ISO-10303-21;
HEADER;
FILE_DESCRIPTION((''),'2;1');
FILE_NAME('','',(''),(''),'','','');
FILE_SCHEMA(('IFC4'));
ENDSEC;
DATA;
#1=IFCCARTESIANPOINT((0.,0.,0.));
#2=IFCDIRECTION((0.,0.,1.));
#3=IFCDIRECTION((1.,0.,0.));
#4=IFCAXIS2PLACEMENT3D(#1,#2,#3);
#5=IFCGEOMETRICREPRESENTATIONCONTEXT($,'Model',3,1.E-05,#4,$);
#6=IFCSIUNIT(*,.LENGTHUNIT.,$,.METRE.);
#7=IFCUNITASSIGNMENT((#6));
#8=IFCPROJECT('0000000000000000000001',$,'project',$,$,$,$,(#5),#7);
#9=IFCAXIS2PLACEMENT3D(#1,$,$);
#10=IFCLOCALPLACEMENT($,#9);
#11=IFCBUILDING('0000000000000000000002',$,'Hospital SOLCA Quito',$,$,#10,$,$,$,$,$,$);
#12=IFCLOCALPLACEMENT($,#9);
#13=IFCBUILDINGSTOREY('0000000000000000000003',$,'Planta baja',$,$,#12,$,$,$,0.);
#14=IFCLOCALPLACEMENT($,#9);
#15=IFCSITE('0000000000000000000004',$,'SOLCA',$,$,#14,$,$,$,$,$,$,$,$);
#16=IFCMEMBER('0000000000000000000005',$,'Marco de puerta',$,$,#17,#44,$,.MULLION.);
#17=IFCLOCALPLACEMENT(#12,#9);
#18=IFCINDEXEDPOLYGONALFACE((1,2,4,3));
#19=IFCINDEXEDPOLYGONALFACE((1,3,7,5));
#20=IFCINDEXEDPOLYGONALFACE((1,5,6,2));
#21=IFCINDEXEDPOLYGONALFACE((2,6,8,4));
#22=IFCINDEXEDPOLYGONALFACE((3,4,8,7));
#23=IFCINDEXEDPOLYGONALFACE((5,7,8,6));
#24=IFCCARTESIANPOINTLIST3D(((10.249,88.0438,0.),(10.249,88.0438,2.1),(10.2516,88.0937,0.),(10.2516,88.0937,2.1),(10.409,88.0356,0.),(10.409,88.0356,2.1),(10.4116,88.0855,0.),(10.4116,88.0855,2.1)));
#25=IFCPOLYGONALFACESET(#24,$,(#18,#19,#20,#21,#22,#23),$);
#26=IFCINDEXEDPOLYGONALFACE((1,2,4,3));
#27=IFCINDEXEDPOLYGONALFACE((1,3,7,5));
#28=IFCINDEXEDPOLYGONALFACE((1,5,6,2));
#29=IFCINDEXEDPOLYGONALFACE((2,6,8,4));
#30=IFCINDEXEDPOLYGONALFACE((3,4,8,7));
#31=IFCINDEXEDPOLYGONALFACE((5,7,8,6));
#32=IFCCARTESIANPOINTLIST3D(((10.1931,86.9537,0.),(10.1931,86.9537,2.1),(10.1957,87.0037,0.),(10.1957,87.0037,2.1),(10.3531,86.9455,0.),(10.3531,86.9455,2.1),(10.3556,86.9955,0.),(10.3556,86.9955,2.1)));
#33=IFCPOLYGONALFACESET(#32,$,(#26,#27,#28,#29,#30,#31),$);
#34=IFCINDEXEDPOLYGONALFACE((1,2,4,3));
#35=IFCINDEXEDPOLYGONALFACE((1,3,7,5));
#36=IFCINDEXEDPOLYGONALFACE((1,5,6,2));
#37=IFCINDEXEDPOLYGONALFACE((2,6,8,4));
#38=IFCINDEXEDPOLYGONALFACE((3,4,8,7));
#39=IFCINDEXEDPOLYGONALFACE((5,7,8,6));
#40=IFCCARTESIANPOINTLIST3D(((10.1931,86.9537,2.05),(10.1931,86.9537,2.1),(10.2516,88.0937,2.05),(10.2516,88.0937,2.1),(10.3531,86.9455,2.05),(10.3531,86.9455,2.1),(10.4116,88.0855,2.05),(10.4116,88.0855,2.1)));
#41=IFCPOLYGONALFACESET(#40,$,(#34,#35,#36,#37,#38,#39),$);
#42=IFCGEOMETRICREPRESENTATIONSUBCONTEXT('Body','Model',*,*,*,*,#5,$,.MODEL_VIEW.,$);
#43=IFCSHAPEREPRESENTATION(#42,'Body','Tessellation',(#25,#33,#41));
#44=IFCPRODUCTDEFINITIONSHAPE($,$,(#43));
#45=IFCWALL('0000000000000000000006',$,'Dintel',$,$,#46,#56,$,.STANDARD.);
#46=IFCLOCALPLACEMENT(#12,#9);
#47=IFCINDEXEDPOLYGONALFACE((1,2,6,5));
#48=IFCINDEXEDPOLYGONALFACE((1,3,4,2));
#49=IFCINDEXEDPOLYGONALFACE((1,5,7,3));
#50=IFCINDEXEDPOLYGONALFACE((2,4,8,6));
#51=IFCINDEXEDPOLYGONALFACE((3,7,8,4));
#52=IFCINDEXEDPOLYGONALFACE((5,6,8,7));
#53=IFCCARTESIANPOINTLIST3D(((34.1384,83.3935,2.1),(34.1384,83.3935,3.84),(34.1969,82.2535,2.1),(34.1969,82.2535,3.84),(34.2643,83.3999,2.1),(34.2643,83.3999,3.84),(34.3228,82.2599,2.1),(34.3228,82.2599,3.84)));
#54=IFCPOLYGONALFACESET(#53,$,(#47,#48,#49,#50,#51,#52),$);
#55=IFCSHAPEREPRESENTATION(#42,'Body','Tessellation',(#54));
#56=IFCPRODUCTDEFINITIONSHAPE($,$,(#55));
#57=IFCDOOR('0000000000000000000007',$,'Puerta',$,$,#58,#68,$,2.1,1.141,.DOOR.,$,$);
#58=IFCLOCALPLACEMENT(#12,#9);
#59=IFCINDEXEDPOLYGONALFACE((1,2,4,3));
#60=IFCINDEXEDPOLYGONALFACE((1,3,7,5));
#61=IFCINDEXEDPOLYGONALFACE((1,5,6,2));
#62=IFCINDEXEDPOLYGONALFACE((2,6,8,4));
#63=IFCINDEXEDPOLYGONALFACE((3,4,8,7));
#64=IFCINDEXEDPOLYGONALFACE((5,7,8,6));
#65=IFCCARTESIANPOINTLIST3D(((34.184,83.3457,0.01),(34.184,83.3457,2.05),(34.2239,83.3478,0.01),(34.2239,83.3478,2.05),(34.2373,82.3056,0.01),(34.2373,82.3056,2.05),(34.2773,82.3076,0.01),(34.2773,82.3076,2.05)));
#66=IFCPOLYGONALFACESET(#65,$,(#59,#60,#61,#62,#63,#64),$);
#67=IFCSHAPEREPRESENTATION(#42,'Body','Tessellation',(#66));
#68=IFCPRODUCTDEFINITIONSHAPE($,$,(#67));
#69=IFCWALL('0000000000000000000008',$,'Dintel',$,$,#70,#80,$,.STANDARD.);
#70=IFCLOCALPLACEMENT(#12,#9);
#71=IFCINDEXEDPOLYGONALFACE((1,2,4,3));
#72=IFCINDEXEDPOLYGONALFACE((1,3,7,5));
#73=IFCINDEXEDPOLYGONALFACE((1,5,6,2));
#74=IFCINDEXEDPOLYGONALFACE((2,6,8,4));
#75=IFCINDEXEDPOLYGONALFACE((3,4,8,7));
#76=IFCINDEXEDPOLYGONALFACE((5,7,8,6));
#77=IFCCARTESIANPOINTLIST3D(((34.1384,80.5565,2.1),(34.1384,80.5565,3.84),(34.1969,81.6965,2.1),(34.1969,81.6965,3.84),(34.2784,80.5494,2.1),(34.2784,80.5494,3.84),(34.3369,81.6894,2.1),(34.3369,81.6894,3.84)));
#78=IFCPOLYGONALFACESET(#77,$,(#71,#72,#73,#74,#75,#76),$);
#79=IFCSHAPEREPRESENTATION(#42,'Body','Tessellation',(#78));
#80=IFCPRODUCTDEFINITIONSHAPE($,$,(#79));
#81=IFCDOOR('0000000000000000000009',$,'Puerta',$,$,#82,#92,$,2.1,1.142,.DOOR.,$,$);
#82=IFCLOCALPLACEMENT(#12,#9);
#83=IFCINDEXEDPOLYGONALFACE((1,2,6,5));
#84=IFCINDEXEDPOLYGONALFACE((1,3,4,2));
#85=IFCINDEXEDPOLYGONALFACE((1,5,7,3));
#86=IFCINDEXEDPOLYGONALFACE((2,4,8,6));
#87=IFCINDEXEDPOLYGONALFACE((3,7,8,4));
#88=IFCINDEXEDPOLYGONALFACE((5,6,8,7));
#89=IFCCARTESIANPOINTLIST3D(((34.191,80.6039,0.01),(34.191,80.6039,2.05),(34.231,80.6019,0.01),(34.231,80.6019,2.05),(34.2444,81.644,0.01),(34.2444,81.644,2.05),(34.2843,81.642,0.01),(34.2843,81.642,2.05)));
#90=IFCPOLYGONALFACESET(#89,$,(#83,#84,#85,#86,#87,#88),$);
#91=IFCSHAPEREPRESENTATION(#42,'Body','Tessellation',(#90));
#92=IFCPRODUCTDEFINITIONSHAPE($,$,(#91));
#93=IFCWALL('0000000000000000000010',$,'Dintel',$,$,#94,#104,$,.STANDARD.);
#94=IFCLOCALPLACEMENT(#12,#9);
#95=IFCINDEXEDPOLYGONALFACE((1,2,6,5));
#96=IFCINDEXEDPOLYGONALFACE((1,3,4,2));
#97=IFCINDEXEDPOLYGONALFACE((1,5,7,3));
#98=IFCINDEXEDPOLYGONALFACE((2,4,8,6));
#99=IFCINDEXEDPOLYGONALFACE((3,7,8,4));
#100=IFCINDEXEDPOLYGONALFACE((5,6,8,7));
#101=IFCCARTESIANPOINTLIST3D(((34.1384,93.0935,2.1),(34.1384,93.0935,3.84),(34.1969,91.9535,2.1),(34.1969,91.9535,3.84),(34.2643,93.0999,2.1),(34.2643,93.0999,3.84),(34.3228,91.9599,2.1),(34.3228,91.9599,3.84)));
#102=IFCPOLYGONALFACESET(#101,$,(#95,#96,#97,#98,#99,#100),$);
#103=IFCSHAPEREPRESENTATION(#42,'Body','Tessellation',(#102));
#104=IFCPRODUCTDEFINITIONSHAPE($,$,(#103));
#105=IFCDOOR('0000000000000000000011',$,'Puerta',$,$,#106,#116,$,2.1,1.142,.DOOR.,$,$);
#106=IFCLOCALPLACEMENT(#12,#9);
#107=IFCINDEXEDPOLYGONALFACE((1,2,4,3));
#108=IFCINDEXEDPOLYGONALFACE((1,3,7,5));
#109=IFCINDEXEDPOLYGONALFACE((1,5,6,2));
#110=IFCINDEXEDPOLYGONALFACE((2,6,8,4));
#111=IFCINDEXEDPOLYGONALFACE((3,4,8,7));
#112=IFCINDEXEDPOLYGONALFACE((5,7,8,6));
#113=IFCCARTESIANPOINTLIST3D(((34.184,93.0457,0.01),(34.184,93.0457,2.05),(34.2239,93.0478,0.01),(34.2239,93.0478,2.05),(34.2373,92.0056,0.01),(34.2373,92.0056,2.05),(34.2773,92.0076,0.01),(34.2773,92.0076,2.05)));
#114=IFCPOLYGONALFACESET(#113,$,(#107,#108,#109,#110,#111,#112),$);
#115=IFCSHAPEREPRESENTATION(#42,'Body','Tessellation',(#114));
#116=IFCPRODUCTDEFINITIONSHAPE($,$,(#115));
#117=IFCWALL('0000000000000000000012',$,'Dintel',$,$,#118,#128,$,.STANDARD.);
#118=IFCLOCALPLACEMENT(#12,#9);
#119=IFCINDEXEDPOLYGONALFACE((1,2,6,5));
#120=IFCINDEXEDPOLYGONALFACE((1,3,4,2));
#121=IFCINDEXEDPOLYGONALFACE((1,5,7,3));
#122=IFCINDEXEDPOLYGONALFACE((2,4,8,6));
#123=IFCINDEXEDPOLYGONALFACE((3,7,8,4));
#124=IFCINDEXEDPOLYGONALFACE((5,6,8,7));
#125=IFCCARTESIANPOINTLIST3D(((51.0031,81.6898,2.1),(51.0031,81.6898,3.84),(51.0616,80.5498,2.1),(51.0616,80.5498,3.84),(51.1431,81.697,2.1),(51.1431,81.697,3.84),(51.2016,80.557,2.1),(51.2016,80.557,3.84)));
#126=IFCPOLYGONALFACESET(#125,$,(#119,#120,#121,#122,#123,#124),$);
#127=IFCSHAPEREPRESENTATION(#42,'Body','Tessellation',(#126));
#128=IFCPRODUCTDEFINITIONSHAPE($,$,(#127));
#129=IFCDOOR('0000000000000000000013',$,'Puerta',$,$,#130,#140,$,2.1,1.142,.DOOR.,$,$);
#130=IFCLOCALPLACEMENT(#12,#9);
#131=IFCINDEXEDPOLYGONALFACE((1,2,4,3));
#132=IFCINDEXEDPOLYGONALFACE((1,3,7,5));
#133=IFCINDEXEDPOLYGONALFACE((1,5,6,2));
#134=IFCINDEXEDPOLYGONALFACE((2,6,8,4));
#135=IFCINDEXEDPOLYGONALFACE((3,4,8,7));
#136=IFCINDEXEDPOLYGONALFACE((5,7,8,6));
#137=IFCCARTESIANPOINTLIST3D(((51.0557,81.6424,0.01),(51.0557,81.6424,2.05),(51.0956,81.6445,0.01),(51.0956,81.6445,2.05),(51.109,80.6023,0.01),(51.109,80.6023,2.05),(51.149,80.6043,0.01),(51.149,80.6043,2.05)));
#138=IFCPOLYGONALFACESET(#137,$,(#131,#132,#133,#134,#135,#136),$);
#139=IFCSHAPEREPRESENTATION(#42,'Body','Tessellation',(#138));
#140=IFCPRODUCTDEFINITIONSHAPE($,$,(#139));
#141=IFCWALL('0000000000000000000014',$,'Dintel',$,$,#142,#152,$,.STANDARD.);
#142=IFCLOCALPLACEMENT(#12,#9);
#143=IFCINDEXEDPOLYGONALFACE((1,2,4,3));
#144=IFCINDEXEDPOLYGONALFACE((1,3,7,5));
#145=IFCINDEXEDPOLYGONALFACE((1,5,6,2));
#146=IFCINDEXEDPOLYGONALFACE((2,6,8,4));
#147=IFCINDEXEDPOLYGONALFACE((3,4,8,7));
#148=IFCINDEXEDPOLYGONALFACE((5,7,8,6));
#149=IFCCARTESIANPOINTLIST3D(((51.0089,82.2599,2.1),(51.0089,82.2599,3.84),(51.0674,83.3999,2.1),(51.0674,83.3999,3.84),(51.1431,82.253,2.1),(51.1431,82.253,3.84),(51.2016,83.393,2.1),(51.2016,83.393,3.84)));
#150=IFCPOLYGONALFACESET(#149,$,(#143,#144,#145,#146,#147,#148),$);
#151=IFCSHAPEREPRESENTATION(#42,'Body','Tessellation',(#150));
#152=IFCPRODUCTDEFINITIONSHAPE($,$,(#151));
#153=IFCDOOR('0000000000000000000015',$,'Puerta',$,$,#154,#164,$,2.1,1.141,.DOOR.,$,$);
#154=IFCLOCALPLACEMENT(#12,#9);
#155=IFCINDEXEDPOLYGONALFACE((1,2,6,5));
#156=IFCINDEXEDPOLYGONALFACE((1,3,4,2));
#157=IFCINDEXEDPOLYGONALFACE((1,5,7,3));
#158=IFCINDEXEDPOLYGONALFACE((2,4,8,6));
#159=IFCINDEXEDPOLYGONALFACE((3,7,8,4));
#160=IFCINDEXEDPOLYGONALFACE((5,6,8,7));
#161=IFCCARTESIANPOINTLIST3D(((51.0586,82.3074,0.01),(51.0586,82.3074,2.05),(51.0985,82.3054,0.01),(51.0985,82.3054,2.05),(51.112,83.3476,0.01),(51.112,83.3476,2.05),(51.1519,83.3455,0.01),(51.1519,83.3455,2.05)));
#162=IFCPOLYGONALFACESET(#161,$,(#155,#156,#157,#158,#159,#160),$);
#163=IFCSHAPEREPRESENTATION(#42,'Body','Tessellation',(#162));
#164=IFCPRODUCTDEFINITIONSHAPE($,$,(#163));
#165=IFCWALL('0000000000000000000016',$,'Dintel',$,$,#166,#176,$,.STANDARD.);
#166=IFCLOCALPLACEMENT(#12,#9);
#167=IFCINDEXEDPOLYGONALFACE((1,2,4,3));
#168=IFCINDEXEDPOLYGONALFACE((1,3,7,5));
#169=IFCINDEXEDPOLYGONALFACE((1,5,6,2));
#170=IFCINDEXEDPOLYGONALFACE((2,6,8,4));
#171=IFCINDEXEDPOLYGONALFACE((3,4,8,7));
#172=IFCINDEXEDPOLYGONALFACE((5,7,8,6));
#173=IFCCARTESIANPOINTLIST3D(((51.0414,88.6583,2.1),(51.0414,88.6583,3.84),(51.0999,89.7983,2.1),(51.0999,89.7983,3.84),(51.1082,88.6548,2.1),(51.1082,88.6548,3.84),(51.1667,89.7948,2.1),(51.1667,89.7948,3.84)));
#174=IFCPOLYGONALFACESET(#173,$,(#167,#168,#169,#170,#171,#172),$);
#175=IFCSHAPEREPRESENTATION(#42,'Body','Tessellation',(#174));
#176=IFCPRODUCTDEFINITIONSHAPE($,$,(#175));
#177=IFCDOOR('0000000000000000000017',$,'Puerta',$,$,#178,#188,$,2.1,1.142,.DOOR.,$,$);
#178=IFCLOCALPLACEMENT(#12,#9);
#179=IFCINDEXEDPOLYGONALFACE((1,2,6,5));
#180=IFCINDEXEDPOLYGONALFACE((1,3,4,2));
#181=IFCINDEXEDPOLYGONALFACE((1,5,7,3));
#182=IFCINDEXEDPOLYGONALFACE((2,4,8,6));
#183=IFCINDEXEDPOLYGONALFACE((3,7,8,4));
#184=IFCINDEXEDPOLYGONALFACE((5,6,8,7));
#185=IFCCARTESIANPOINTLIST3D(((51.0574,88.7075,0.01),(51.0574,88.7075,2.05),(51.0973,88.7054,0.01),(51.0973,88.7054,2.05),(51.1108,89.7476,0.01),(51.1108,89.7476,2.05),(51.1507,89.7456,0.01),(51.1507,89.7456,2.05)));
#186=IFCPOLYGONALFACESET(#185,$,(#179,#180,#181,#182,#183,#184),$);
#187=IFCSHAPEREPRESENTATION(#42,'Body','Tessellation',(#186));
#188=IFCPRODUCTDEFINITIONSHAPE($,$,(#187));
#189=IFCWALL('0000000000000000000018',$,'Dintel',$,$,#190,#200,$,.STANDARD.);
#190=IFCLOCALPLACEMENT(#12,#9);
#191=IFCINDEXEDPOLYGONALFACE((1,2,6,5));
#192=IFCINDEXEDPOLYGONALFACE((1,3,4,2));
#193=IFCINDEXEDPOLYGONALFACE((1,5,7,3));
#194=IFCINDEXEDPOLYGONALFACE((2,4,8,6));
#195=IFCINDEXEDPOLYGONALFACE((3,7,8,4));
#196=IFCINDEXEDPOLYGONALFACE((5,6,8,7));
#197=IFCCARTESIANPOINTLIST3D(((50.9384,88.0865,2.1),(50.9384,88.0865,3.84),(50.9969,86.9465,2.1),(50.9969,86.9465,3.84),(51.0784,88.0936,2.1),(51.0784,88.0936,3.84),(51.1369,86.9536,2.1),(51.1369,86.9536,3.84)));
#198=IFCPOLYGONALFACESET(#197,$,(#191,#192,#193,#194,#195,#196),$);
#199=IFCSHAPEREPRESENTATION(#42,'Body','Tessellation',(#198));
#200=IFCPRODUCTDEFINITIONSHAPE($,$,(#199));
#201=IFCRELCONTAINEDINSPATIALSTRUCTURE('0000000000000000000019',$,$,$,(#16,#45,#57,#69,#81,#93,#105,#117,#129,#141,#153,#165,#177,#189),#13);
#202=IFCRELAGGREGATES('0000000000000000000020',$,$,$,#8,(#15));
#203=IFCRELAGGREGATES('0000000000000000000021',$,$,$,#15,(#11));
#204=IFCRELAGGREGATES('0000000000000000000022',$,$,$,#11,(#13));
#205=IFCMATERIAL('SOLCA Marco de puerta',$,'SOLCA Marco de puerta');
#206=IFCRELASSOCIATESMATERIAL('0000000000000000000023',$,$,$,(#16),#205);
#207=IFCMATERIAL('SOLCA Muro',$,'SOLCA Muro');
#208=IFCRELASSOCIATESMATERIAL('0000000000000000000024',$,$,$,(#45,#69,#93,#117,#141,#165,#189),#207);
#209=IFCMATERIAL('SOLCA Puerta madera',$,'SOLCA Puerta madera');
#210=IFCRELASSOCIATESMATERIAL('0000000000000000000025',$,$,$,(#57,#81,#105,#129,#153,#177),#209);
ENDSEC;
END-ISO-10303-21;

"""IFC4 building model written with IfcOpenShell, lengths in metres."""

from ifc_helpers import new_model, si_unit, frame, origin, origin_with_axes, place, context, subcontext, project, spatial, polyline, outline, extrude, material, element, save


model = new_model("IFC4")

# Units and contexts
model_context = context("Model", 3, precision=1e-05, world=origin_with_axes())
body_context = subcontext(model_context, "Body", "Model", "MODEL_VIEW")
ifc_project = project(units=[si_unit("LENGTHUNIT", "METRE")], contexts=[model_context])

# Site, building, storey
site_placement = place(None, origin())
site = spatial("IfcSite", under=ifc_project, at=site_placement, Name="SOLCA")
building_placement = place(None, origin())
building = spatial("IfcBuilding", under=site, at=building_placement, Name="Hospital SOLCA Quito")
storey_placement = place(None, origin())
storey = spatial("IfcBuildingStorey", under=building, at=storey_placement, Name="Planta baja", Elevation=0.0)

# Member
ifc_material_1 = material(Name="SOLCA Marco de puerta", Category="SOLCA Marco de puerta")
member_1_placement = place(storey_placement, origin_with_axes())
element("IfcMember", 1, at=member_1_placement, inside=storey, material=ifc_material_1, Name="Marco de puerta", PredefinedType="MULLION", context=body_context, shape_type="SweptSolid", body=[
    extrude(outline(polyline([(10.2516, 88.0937), (10.249, 88.0438), (10.409, 88.0356), (10.4116, 88.0855), (10.2516, 88.0937)])), origin_with_axes(), (0.0, 0.0, 1.0), 2.1),
    extrude(outline(polyline([(10.1957, 87.0037), (10.1931, 86.9537), (10.3531, 86.9455), (10.3556, 86.9955), (10.1957, 87.0037)])), origin_with_axes(), (0.0, 0.0, 1.0), 2.1),
    extrude(outline(polyline([(10.2516, 88.0937), (10.1931, 86.9537), (10.3531, 86.9455), (10.4116, 88.0855), (10.2516, 88.0937)])), frame((0.0, 0.0, 2.05), z_axis=(0.0, 0.0, 1.0), x_axis=(1.0, 0.0, 0.0)), (0.0, 0.0, 1.0), 0.05),
])

# Wall
ifc_material_2 = material(Name="SOLCA Muro", Category="SOLCA Muro")
wall_1_placement = place(storey_placement, origin_with_axes())
element("IfcWall", 2, at=wall_1_placement, inside=storey, material=ifc_material_2, Name="Dintel", PredefinedType="STANDARD", context=body_context, shape_type="SweptSolid", body=[
    extrude(outline(polyline([(34.3228, 82.2599), (34.2643, 83.3999), (34.1384, 83.3935), (34.1969, 82.2535), (34.3228, 82.2599)])), frame((0.0, 0.0, 2.1), z_axis=(0.0, 0.0, 1.0), x_axis=(1.0, 0.0, 0.0)), (0.0, 0.0, 1.0), 1.74),
])

# Door
ifc_material_3 = material(Name="SOLCA Puerta madera", Category="SOLCA Puerta madera")
door_1_placement = place(storey_placement, origin_with_axes())
element("IfcDoor", 3, at=door_1_placement, inside=storey, material=ifc_material_3, Name="Puerta", OverallHeight=2.1, OverallWidth=1.141, PredefinedType="DOOR", context=body_context, shape_type="SweptSolid", body=[
    extrude(outline(polyline([(34.2773, 82.3076), (34.2239, 83.3478), (34.184, 83.3457), (34.2373, 82.3056), (34.2773, 82.3076)])), frame((0.0, 0.0, 0.01), z_axis=(0.0, 0.0, 1.0), x_axis=(1.0, 0.0, 0.0)), (0.0, 0.0, 1.0), 2.04),
])

# Wall
wall_2_placement = place(storey_placement, origin_with_axes())
element("IfcWall", 4, at=wall_2_placement, inside=storey, material=ifc_material_2, Name="Dintel", PredefinedType="STANDARD", context=body_context, shape_type="SweptSolid", body=[
    extrude(outline(polyline([(34.1969, 81.6965), (34.1384, 80.5565), (34.2784, 80.5494), (34.3369, 81.6894), (34.1969, 81.6965)])), frame((0.0, 0.0, 2.1), z_axis=(0.0, 0.0, 1.0), x_axis=(1.0, 0.0, 0.0)), (0.0, 0.0, 1.0), 1.74),
])

# Door
door_2_placement = place(storey_placement, origin_with_axes())
element("IfcDoor", 5, at=door_2_placement, inside=storey, material=ifc_material_3, Name="Puerta", OverallHeight=2.1, OverallWidth=1.142, PredefinedType="DOOR", context=body_context, shape_type="SweptSolid", body=[
    extrude(outline(polyline([(34.2444, 81.644), (34.191, 80.6039), (34.231, 80.6019), (34.2843, 81.642), (34.2444, 81.644)])), frame((0.0, 0.0, 0.01), z_axis=(0.0, 0.0, 1.0), x_axis=(1.0, 0.0, 0.0)), (0.0, 0.0, 1.0), 2.04),
])

# Wall
wall_3_placement = place(storey_placement, origin_with_axes())
element("IfcWall", 6, at=wall_3_placement, inside=storey, material=ifc_material_2, Name="Dintel", PredefinedType="STANDARD", context=body_context, shape_type="SweptSolid", body=[
    extrude(outline(polyline([(34.3228, 91.9599), (34.2643, 93.0999), (34.1384, 93.0935), (34.1969, 91.9535), (34.3228, 91.9599)])), frame((0.0, 0.0, 2.1), z_axis=(0.0, 0.0, 1.0), x_axis=(1.0, 0.0, 0.0)), (0.0, 0.0, 1.0), 1.74),
])

# Door
door_3_placement = place(storey_placement, origin_with_axes())
element("IfcDoor", 7, at=door_3_placement, inside=storey, material=ifc_material_3, Name="Puerta", OverallHeight=2.1, OverallWidth=1.142, PredefinedType="DOOR", context=body_context, shape_type="SweptSolid", body=[
    extrude(outline(polyline([(34.2773, 92.0076), (34.2239, 93.0478), (34.184, 93.0457), (34.2373, 92.0056), (34.2773, 92.0076)])), frame((0.0, 0.0, 0.01), z_axis=(0.0, 0.0, 1.0), x_axis=(1.0, 0.0, 0.0)), (0.0, 0.0, 1.0), 2.04),
])

# Wall
wall_4_placement = place(storey_placement, origin_with_axes())
element("IfcWall", 8, at=wall_4_placement, inside=storey, material=ifc_material_2, Name="Dintel", PredefinedType="STANDARD", context=body_context, shape_type="SweptSolid", body=[
    extrude(outline(polyline([(51.0031, 81.6898), (51.0616, 80.5498), (51.2016, 80.557), (51.1431, 81.697), (51.0031, 81.6898)])), frame((0.0, 0.0, 2.1), z_axis=(0.0, 0.0, 1.0), x_axis=(1.0, 0.0, 0.0)), (0.0, 0.0, 1.0), 1.74),
])

# Door
door_4_placement = place(storey_placement, origin_with_axes())
element("IfcDoor", 9, at=door_4_placement, inside=storey, material=ifc_material_3, Name="Puerta", OverallHeight=2.1, OverallWidth=1.142, PredefinedType="DOOR", context=body_context, shape_type="SweptSolid", body=[
    extrude(outline(polyline([(51.0557, 81.6424), (51.109, 80.6023), (51.149, 80.6043), (51.0956, 81.6445), (51.0557, 81.6424)])), frame((0.0, 0.0, 0.01), z_axis=(0.0, 0.0, 1.0), x_axis=(1.0, 0.0, 0.0)), (0.0, 0.0, 1.0), 2.04),
])

# Wall
wall_5_placement = place(storey_placement, origin_with_axes())
element("IfcWall", 10, at=wall_5_placement, inside=storey, material=ifc_material_2, Name="Dintel", PredefinedType="STANDARD", context=body_context, shape_type="SweptSolid", body=[
    extrude(outline(polyline([(51.1431, 82.253), (51.2016, 83.393), (51.0674, 83.3999), (51.0089, 82.2599), (51.1431, 82.253)])), frame((0.0, 0.0, 2.1), z_axis=(0.0, 0.0, 1.0), x_axis=(1.0, 0.0, 0.0)), (0.0, 0.0, 1.0), 1.74),
])

# Door
door_5_placement = place(storey_placement, origin_with_axes())
element("IfcDoor", 11, at=door_5_placement, inside=storey, material=ifc_material_3, Name="Puerta", OverallHeight=2.1, OverallWidth=1.141, PredefinedType="DOOR", context=body_context, shape_type="SweptSolid", body=[
    extrude(outline(polyline([(51.0985, 82.3054), (51.1519, 83.3455), (51.112, 83.3476), (51.0586, 82.3074), (51.0985, 82.3054)])), frame((0.0, 0.0, 0.01), z_axis=(0.0, 0.0, 1.0), x_axis=(1.0, 0.0, 0.0)), (0.0, 0.0, 1.0), 2.04),
])

# Wall
wall_6_placement = place(storey_placement, origin_with_axes())
element("IfcWall", 12, at=wall_6_placement, inside=storey, material=ifc_material_2, Name="Dintel", PredefinedType="STANDARD", context=body_context, shape_type="SweptSolid", body=[
    extrude(outline(polyline([(51.1082, 88.6548), (51.1667, 89.7948), (51.0999, 89.7983), (51.0414, 88.6583), (51.1082, 88.6548)])), frame((0.0, 0.0, 2.1), z_axis=(0.0, 0.0, 1.0), x_axis=(1.0, 0.0, 0.0)), (0.0, 0.0, 1.0), 1.74),
])

# Door
door_6_placement = place(storey_placement, origin_with_axes())
element("IfcDoor", 13, at=door_6_placement, inside=storey, material=ifc_material_3, Name="Puerta", OverallHeight=2.1, OverallWidth=1.142, PredefinedType="DOOR", context=body_context, shape_type="SweptSolid", body=[
    extrude(outline(polyline([(51.0973, 88.7054), (51.1507, 89.7456), (51.1108, 89.7476), (51.0574, 88.7075), (51.0973, 88.7054)])), frame((0.0, 0.0, 0.01), z_axis=(0.0, 0.0, 1.0), x_axis=(1.0, 0.0, 0.0)), (0.0, 0.0, 1.0), 2.04),
])

# Wall
wall_7_placement = place(storey_placement, origin_with_axes())
element("IfcWall", 14, at=wall_7_placement, inside=storey, material=ifc_material_2, Name="Dintel", PredefinedType="STANDARD", context=body_context, shape_type="SweptSolid", body=[
    extrude(outline(polyline([(50.9384, 88.0865), (50.9969, 86.9465), (51.1369, 86.9536), (51.0784, 88.0936), (50.9384, 88.0865)])), frame((0.0, 0.0, 2.1), z_axis=(0.0, 0.0, 1.0), x_axis=(1.0, 0.0, 0.0)), (0.0, 0.0, 1.0), 1.74),
])

save(model, "model.ifc")
